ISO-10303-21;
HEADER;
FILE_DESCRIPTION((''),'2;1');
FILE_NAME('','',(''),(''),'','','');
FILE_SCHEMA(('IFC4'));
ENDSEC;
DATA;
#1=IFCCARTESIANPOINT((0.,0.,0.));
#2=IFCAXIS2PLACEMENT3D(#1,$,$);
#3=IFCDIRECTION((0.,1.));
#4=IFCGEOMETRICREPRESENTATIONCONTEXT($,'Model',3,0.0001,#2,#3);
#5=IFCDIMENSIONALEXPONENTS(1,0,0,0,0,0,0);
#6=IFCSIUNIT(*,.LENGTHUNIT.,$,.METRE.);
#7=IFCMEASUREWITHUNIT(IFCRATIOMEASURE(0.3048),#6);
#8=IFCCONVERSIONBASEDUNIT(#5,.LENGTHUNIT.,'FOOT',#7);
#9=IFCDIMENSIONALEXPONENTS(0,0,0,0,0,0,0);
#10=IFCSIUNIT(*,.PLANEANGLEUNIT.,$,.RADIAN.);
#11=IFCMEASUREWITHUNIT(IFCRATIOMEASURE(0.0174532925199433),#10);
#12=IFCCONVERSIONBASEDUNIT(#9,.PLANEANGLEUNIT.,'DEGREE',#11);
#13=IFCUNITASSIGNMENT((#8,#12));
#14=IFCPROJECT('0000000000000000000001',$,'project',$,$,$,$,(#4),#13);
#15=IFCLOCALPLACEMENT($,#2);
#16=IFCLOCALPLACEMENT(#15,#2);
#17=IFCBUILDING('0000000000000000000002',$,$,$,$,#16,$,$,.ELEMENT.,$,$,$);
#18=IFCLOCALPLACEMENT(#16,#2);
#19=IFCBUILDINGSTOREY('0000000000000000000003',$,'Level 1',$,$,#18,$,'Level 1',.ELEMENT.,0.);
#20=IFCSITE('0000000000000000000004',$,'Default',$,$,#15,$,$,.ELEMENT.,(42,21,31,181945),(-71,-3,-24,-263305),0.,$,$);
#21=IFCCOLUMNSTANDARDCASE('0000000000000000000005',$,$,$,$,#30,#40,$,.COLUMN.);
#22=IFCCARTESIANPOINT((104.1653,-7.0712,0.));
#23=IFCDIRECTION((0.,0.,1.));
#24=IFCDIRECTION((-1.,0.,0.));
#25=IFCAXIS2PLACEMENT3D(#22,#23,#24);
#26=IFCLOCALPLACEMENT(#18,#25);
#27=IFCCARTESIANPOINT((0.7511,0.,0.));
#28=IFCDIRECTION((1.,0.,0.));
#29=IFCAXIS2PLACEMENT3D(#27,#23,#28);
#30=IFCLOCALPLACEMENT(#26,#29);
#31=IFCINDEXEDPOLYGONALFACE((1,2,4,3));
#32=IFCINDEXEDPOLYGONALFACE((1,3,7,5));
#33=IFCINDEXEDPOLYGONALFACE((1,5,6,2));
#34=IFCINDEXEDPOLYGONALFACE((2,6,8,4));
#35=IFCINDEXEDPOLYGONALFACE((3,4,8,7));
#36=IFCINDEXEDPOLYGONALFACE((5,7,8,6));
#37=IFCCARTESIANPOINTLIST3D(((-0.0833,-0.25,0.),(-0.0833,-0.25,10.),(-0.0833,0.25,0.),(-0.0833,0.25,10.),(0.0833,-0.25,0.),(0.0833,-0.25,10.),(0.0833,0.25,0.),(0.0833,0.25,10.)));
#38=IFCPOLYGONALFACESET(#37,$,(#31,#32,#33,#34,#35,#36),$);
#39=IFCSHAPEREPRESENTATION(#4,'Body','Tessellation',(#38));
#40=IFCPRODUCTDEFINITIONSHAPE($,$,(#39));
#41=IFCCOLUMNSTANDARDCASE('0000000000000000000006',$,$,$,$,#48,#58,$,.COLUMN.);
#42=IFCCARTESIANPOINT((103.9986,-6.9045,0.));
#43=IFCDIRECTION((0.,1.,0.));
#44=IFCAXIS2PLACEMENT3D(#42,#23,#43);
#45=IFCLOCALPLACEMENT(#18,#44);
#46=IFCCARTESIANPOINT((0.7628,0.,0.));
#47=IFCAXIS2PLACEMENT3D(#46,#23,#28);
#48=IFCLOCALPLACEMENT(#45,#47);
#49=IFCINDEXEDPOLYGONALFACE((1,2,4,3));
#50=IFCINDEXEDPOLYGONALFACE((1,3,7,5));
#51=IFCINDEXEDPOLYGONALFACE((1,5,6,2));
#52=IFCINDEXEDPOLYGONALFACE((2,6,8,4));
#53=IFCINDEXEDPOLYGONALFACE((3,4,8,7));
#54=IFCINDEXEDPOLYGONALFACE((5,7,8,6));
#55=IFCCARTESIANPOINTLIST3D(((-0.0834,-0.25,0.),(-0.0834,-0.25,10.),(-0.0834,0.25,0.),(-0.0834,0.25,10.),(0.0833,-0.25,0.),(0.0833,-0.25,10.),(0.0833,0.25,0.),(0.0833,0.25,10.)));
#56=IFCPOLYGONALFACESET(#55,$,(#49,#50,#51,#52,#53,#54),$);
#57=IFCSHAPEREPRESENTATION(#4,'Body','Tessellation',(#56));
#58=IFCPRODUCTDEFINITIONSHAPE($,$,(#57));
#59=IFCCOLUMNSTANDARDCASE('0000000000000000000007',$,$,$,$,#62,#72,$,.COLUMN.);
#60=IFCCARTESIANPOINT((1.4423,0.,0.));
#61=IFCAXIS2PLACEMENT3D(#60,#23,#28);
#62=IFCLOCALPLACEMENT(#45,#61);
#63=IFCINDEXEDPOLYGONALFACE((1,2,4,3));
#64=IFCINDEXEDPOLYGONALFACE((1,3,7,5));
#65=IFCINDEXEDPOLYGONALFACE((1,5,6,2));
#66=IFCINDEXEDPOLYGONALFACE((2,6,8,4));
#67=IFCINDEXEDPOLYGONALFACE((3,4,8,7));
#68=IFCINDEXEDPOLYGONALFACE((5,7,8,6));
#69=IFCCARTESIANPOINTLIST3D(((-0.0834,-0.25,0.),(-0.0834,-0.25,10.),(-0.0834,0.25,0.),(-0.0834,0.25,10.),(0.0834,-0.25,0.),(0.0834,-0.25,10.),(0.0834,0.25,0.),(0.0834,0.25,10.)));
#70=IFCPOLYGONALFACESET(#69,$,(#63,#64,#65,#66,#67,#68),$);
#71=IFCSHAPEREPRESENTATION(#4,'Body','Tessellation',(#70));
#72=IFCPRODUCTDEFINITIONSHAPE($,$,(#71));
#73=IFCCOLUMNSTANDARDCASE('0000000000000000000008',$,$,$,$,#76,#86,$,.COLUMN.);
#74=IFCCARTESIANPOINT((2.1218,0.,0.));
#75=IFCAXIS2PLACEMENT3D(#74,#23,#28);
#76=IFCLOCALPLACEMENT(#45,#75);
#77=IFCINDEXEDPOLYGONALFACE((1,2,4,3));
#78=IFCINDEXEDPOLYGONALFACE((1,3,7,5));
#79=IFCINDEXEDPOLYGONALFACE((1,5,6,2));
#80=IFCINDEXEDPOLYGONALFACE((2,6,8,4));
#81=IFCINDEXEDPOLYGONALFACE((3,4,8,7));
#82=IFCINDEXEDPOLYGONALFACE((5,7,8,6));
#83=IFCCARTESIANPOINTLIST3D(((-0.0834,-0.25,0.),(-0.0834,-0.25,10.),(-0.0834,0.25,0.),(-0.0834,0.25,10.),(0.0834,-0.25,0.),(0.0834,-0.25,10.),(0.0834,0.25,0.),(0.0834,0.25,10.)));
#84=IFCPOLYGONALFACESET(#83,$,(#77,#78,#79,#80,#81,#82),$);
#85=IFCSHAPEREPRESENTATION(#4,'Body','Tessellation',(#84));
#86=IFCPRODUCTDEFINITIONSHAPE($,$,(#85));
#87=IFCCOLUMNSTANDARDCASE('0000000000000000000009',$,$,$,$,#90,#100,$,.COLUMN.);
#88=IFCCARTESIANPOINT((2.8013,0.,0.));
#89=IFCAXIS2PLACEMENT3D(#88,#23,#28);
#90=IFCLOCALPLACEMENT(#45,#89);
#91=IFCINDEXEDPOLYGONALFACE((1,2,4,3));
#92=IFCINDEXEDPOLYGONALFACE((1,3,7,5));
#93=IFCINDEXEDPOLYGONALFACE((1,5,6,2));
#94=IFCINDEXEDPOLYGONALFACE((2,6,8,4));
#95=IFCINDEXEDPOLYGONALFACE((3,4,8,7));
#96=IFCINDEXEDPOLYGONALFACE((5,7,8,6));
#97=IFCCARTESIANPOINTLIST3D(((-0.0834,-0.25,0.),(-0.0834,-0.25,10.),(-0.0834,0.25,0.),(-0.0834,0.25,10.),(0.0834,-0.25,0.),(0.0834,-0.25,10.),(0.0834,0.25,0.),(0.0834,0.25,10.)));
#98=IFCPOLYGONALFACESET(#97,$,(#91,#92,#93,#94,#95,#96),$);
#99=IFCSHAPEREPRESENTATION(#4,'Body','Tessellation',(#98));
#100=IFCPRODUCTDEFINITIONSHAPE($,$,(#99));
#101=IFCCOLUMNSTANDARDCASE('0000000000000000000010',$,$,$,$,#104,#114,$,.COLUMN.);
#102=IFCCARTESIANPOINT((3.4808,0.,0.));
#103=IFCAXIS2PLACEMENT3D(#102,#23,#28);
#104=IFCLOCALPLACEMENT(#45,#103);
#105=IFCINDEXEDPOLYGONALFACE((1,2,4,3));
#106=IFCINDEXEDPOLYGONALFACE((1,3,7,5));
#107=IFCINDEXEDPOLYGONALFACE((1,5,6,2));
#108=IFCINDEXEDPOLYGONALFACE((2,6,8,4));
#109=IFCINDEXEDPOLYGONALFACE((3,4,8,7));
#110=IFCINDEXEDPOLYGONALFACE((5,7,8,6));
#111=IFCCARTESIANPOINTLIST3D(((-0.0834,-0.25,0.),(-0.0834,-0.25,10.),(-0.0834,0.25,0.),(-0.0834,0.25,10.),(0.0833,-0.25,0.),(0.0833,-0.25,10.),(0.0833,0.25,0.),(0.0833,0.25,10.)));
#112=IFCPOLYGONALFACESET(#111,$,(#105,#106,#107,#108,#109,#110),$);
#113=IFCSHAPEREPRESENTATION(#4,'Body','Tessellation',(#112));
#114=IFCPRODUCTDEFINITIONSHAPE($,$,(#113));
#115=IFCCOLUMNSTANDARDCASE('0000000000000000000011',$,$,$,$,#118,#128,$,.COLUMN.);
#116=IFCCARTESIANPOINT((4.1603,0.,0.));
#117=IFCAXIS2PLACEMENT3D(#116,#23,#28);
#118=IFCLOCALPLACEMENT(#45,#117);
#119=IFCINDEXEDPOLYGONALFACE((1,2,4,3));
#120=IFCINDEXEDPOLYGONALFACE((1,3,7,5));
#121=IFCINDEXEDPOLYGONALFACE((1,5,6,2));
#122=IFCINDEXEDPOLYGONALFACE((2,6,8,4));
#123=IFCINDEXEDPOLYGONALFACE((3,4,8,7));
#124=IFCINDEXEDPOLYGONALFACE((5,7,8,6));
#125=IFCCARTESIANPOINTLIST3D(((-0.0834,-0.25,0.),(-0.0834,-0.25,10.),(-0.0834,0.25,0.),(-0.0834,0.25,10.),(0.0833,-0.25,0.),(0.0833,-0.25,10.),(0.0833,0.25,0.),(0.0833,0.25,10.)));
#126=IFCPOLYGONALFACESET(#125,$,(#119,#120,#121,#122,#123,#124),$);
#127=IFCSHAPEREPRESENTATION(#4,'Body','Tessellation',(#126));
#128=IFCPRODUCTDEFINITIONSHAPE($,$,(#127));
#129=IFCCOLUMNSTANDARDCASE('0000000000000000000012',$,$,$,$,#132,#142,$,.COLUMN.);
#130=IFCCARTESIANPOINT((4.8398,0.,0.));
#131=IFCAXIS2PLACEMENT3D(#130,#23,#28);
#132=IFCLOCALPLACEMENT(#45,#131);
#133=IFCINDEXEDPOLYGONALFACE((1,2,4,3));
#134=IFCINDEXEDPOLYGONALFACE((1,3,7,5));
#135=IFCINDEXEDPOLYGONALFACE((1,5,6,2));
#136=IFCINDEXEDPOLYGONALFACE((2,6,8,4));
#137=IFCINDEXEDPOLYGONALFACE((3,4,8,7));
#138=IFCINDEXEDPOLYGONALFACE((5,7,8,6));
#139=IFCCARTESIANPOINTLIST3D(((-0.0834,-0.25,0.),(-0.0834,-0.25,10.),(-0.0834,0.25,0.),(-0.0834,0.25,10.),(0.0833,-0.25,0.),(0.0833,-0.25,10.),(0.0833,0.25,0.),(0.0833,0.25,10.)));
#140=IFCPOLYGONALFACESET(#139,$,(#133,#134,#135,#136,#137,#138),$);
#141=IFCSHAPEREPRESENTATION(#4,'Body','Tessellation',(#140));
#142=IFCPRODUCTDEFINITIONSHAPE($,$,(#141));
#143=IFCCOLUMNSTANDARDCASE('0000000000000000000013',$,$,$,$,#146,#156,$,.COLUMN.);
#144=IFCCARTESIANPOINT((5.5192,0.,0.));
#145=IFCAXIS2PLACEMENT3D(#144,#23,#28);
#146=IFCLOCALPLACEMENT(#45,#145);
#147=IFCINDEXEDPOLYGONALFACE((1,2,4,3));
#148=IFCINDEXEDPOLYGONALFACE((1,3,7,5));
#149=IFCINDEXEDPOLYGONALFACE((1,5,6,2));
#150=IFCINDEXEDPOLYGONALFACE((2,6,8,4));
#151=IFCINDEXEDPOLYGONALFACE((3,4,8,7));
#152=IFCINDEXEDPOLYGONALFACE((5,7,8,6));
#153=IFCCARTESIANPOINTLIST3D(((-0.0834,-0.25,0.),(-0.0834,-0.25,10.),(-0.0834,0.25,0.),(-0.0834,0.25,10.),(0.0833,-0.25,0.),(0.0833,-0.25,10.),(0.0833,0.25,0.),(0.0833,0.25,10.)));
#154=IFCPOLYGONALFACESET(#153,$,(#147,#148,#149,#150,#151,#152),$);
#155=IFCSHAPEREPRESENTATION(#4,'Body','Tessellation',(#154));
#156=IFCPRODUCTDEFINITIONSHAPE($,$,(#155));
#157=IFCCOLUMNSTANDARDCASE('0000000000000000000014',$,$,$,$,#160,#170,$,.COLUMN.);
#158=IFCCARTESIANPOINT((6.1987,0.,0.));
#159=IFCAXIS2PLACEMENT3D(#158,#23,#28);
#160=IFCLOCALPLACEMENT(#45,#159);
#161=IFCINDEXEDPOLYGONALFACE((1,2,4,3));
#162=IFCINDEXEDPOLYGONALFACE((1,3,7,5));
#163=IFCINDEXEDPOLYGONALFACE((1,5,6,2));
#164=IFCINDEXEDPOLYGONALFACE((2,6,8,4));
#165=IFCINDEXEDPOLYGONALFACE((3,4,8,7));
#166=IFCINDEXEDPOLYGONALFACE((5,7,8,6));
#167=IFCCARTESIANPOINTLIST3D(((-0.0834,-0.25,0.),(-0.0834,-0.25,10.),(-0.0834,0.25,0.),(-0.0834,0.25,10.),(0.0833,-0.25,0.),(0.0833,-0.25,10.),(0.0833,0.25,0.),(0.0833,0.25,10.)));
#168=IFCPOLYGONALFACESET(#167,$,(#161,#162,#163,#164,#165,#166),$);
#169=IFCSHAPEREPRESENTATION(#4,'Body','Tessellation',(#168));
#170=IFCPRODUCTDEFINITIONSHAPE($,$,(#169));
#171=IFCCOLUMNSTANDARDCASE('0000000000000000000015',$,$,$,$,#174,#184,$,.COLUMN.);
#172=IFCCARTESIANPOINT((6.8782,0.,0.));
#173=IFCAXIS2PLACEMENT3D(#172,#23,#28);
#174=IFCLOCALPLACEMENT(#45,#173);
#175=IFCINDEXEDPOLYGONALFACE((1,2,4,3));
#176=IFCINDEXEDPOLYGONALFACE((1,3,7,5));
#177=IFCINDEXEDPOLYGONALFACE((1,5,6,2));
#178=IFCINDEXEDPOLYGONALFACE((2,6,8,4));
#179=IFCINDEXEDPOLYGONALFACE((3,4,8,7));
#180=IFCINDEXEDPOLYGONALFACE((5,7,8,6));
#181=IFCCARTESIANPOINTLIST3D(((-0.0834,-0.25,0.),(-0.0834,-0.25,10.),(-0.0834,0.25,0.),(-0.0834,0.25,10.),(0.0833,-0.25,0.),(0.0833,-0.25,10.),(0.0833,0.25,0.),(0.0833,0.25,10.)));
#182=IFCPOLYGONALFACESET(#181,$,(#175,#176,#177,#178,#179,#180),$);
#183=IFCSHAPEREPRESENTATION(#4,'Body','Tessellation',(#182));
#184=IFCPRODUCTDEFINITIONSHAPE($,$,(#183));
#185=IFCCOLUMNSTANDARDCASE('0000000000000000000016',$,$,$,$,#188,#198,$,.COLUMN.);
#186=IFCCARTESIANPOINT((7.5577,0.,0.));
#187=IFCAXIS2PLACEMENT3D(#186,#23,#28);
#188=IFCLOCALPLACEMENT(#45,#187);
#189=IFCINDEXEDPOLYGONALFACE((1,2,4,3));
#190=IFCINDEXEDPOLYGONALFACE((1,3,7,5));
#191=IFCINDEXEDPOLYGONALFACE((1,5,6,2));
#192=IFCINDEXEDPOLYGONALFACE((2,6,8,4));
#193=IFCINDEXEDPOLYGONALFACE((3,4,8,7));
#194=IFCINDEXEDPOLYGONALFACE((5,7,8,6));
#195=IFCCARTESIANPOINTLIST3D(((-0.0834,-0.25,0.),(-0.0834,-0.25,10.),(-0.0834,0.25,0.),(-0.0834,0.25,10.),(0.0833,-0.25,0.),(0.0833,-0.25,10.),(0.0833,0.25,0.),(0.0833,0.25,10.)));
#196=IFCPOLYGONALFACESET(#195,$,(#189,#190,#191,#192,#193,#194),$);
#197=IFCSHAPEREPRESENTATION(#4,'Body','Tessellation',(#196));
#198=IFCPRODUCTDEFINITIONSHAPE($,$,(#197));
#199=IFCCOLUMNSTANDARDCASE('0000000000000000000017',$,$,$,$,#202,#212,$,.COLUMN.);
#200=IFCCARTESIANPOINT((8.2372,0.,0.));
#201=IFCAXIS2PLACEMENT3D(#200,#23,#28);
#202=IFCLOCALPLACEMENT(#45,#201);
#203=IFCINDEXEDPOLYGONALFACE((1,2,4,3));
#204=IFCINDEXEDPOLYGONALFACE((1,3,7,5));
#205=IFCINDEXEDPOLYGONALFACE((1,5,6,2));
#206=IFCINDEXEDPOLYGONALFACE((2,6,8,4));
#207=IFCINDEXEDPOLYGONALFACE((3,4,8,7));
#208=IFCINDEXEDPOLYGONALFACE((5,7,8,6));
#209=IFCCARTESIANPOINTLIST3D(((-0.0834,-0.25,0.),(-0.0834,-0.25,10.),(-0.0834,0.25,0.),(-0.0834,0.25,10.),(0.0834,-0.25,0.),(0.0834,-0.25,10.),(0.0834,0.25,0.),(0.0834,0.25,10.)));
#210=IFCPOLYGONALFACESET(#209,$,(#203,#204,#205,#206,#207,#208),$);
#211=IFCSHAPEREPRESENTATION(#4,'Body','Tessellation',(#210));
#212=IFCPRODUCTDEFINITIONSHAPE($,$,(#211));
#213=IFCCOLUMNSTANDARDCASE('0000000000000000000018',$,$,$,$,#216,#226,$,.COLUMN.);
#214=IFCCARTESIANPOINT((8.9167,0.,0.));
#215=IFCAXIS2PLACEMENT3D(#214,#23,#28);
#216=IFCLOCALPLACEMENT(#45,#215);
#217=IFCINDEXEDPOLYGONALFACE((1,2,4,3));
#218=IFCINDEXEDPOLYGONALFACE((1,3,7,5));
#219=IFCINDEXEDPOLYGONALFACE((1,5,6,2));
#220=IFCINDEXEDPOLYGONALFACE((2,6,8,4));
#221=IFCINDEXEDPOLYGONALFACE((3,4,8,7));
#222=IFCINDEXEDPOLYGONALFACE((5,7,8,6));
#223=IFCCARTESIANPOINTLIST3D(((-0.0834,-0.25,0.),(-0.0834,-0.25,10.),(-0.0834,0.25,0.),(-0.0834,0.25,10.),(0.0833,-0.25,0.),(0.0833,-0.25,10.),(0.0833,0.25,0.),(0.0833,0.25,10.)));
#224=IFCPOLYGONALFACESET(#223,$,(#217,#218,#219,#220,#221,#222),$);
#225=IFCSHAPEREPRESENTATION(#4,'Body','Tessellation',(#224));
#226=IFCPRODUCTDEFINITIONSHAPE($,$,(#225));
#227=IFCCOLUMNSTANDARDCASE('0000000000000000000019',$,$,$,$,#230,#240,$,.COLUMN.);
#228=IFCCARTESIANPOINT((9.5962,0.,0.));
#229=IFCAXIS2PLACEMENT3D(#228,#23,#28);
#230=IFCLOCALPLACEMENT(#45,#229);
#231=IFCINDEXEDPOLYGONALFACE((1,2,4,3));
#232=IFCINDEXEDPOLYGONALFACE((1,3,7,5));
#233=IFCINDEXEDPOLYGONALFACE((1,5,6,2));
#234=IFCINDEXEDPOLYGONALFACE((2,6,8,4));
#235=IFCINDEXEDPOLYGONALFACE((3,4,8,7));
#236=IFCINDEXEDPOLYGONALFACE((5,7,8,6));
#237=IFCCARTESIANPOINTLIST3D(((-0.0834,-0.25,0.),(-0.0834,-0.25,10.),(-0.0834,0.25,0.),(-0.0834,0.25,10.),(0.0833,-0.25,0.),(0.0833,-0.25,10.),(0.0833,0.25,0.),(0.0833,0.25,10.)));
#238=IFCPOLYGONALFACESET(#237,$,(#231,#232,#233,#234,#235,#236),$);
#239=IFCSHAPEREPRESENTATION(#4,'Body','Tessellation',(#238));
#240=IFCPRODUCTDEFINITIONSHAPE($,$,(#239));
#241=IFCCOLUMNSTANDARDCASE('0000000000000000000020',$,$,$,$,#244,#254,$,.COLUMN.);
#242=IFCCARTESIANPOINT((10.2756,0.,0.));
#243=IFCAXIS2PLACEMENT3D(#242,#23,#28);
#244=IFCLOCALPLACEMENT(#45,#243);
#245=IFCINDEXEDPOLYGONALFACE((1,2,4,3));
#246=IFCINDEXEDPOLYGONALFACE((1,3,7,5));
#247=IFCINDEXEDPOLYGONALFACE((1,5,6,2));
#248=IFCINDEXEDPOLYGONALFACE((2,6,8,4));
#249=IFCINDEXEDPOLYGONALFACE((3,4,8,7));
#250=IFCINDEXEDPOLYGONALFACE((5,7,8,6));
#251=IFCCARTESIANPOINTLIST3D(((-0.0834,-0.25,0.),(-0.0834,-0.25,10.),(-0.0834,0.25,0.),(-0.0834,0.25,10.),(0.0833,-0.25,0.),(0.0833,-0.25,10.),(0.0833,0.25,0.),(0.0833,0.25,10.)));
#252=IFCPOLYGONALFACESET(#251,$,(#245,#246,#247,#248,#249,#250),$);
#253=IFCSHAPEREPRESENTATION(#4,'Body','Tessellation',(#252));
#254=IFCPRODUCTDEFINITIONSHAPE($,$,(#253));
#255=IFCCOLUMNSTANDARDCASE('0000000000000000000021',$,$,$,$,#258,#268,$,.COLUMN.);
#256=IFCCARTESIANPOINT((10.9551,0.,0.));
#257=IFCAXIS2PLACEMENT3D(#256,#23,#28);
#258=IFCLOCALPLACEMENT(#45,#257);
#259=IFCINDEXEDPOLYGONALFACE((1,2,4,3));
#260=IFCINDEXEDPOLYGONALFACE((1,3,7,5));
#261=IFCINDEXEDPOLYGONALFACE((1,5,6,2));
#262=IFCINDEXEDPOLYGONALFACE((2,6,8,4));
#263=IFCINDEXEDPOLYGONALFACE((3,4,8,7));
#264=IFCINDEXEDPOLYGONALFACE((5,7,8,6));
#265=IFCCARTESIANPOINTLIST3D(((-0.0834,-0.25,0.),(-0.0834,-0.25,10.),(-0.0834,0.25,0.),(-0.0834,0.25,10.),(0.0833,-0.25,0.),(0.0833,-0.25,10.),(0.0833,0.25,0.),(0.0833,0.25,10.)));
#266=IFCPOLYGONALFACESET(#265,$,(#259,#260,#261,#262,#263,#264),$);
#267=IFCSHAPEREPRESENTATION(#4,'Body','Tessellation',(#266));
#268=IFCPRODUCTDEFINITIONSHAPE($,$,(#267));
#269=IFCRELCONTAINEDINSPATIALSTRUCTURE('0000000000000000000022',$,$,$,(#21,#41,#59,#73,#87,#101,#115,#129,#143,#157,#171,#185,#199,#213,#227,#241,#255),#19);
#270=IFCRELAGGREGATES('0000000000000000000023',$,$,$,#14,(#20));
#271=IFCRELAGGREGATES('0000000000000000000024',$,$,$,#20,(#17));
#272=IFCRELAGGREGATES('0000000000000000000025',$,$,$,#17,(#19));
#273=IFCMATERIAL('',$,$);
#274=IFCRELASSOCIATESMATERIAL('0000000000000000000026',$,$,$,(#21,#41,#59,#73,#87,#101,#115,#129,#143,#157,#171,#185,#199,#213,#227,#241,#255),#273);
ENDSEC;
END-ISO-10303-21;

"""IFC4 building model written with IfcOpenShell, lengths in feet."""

from ifc_helpers import new_model, entity, si_unit, converted_unit, direction, frame, origin, place, context, project, spatial, rectangle, extrude, material, element, save


model = new_model("IFC4")

# Units and contexts
model_context = context("Model", 3, precision=0.0001, world=origin(), true_north=direction((0.0, 1.0)))
ifc_project = project(units=[converted_unit("LENGTHUNIT", "FOOT", entity("IfcRatioMeasure", 0.3048), si_unit("LENGTHUNIT", "METRE"), dimensions=[1, 0, 0, 0, 0, 0, 0]), converted_unit("PLANEANGLEUNIT", "DEGREE", entity("IfcRatioMeasure", 0.0174532925199433), si_unit("PLANEANGLEUNIT", "RADIAN"), dimensions=[0, 0, 0, 0, 0, 0, 0])], contexts=[model_context])

# Site, building, storey
site_placement = place(None, origin())
site = spatial("IfcSite", under=ifc_project, at=site_placement, Name="Default", CompositionType="ELEMENT", RefLatitude=(42, 21, 31, 181945), RefLongitude=(-71, -3, -24, -263305), RefElevation=0.0)
building_placement = place(site_placement, origin())
building = spatial("IfcBuilding", under=site, at=building_placement, CompositionType="ELEMENT")
storey_placement = place(building_placement, origin())
storey = spatial("IfcBuildingStorey", under=building, at=storey_placement, Name="Level 1", LongName="Level 1", CompositionType="ELEMENT", Elevation=0.0)

# Columns
ifc_material_1 = material(Name="")
wall_1_placement = place(storey_placement, frame((104.1653, -7.0712, 0.0), z_axis=(0.0, 0.0, 1.0), x_axis=(-1.0, 0.0, 0.0)))
for number, where, z_axis, x_axis in (
    (1, (0.7511, 0.0, 0.0), (0.0, 0.0, 1.0), (1.0, 0.0, 0.0)),
):
    element("IfcColumnStandardCase", number, at=place(wall_1_placement, frame(where, z_axis=z_axis, x_axis=x_axis)), inside=storey, material=ifc_material_1, PredefinedType="COLUMN", context=model_context, shape_type="SweptSolid", body=[
        extrude(rectangle(XDim=0.1667, YDim=0.5), origin(), (0.0, 0.0, 1.0), 10.0),
    ])
wall_2_placement = place(storey_placement, frame((103.9986, -6.9045, 0.0), z_axis=(0.0, 0.0, 1.0), x_axis=(0.0, 1.0, 0.0)))
for number, where, z_axis, x_axis in (
    (2, (0.7628, 0.0, 0.0), (0.0, 0.0, 1.0), (1.0, 0.0, 0.0)),
    (3, (1.4423, 0.0, 0.0), (0.0, 0.0, 1.0), (1.0, 0.0, 0.0)),
    (4, (2.1218, 0.0, 0.0), (0.0, 0.0, 1.0), (1.0, 0.0, 0.0)),
    (5, (2.8013, 0.0, 0.0), (0.0, 0.0, 1.0), (1.0, 0.0, 0.0)),
    (6, (3.4808, 0.0, 0.0), (0.0, 0.0, 1.0), (1.0, 0.0, 0.0)),
    (7, (4.1603, 0.0, 0.0), (0.0, 0.0, 1.0), (1.0, 0.0, 0.0)),
    (8, (4.8398, 0.0, 0.0), (0.0, 0.0, 1.0), (1.0, 0.0, 0.0)),
    (9, (5.5192, 0.0, 0.0), (0.0, 0.0, 1.0), (1.0, 0.0, 0.0)),
    (10, (6.1987, 0.0, 0.0), (0.0, 0.0, 1.0), (1.0, 0.0, 0.0)),
    (11, (6.8782, 0.0, 0.0), (0.0, 0.0, 1.0), (1.0, 0.0, 0.0)),
    (12, (7.5577, 0.0, 0.0), (0.0, 0.0, 1.0), (1.0, 0.0, 0.0)),
    (13, (8.2372, 0.0, 0.0), (0.0, 0.0, 1.0), (1.0, 0.0, 0.0)),
    (14, (8.9167, 0.0, 0.0), (0.0, 0.0, 1.0), (1.0, 0.0, 0.0)),
    (15, (9.5962, 0.0, 0.0), (0.0, 0.0, 1.0), (1.0, 0.0, 0.0)),
    (16, (10.2756, 0.0, 0.0), (0.0, 0.0, 1.0), (1.0, 0.0, 0.0)),
    (17, (10.9551, 0.0, 0.0), (0.0, 0.0, 1.0), (1.0, 0.0, 0.0)),
):
    element("IfcColumnStandardCase", number, at=place(wall_2_placement, frame(where, z_axis=z_axis, x_axis=x_axis)), inside=storey, material=ifc_material_1, PredefinedType="COLUMN", context=model_context, shape_type="SweptSolid", body=[
        extrude(rectangle(XDim=0.1667, YDim=0.5), origin(), (0.0, 0.0, 1.0), 10.0),
    ])

save(model, "model.ifc")
